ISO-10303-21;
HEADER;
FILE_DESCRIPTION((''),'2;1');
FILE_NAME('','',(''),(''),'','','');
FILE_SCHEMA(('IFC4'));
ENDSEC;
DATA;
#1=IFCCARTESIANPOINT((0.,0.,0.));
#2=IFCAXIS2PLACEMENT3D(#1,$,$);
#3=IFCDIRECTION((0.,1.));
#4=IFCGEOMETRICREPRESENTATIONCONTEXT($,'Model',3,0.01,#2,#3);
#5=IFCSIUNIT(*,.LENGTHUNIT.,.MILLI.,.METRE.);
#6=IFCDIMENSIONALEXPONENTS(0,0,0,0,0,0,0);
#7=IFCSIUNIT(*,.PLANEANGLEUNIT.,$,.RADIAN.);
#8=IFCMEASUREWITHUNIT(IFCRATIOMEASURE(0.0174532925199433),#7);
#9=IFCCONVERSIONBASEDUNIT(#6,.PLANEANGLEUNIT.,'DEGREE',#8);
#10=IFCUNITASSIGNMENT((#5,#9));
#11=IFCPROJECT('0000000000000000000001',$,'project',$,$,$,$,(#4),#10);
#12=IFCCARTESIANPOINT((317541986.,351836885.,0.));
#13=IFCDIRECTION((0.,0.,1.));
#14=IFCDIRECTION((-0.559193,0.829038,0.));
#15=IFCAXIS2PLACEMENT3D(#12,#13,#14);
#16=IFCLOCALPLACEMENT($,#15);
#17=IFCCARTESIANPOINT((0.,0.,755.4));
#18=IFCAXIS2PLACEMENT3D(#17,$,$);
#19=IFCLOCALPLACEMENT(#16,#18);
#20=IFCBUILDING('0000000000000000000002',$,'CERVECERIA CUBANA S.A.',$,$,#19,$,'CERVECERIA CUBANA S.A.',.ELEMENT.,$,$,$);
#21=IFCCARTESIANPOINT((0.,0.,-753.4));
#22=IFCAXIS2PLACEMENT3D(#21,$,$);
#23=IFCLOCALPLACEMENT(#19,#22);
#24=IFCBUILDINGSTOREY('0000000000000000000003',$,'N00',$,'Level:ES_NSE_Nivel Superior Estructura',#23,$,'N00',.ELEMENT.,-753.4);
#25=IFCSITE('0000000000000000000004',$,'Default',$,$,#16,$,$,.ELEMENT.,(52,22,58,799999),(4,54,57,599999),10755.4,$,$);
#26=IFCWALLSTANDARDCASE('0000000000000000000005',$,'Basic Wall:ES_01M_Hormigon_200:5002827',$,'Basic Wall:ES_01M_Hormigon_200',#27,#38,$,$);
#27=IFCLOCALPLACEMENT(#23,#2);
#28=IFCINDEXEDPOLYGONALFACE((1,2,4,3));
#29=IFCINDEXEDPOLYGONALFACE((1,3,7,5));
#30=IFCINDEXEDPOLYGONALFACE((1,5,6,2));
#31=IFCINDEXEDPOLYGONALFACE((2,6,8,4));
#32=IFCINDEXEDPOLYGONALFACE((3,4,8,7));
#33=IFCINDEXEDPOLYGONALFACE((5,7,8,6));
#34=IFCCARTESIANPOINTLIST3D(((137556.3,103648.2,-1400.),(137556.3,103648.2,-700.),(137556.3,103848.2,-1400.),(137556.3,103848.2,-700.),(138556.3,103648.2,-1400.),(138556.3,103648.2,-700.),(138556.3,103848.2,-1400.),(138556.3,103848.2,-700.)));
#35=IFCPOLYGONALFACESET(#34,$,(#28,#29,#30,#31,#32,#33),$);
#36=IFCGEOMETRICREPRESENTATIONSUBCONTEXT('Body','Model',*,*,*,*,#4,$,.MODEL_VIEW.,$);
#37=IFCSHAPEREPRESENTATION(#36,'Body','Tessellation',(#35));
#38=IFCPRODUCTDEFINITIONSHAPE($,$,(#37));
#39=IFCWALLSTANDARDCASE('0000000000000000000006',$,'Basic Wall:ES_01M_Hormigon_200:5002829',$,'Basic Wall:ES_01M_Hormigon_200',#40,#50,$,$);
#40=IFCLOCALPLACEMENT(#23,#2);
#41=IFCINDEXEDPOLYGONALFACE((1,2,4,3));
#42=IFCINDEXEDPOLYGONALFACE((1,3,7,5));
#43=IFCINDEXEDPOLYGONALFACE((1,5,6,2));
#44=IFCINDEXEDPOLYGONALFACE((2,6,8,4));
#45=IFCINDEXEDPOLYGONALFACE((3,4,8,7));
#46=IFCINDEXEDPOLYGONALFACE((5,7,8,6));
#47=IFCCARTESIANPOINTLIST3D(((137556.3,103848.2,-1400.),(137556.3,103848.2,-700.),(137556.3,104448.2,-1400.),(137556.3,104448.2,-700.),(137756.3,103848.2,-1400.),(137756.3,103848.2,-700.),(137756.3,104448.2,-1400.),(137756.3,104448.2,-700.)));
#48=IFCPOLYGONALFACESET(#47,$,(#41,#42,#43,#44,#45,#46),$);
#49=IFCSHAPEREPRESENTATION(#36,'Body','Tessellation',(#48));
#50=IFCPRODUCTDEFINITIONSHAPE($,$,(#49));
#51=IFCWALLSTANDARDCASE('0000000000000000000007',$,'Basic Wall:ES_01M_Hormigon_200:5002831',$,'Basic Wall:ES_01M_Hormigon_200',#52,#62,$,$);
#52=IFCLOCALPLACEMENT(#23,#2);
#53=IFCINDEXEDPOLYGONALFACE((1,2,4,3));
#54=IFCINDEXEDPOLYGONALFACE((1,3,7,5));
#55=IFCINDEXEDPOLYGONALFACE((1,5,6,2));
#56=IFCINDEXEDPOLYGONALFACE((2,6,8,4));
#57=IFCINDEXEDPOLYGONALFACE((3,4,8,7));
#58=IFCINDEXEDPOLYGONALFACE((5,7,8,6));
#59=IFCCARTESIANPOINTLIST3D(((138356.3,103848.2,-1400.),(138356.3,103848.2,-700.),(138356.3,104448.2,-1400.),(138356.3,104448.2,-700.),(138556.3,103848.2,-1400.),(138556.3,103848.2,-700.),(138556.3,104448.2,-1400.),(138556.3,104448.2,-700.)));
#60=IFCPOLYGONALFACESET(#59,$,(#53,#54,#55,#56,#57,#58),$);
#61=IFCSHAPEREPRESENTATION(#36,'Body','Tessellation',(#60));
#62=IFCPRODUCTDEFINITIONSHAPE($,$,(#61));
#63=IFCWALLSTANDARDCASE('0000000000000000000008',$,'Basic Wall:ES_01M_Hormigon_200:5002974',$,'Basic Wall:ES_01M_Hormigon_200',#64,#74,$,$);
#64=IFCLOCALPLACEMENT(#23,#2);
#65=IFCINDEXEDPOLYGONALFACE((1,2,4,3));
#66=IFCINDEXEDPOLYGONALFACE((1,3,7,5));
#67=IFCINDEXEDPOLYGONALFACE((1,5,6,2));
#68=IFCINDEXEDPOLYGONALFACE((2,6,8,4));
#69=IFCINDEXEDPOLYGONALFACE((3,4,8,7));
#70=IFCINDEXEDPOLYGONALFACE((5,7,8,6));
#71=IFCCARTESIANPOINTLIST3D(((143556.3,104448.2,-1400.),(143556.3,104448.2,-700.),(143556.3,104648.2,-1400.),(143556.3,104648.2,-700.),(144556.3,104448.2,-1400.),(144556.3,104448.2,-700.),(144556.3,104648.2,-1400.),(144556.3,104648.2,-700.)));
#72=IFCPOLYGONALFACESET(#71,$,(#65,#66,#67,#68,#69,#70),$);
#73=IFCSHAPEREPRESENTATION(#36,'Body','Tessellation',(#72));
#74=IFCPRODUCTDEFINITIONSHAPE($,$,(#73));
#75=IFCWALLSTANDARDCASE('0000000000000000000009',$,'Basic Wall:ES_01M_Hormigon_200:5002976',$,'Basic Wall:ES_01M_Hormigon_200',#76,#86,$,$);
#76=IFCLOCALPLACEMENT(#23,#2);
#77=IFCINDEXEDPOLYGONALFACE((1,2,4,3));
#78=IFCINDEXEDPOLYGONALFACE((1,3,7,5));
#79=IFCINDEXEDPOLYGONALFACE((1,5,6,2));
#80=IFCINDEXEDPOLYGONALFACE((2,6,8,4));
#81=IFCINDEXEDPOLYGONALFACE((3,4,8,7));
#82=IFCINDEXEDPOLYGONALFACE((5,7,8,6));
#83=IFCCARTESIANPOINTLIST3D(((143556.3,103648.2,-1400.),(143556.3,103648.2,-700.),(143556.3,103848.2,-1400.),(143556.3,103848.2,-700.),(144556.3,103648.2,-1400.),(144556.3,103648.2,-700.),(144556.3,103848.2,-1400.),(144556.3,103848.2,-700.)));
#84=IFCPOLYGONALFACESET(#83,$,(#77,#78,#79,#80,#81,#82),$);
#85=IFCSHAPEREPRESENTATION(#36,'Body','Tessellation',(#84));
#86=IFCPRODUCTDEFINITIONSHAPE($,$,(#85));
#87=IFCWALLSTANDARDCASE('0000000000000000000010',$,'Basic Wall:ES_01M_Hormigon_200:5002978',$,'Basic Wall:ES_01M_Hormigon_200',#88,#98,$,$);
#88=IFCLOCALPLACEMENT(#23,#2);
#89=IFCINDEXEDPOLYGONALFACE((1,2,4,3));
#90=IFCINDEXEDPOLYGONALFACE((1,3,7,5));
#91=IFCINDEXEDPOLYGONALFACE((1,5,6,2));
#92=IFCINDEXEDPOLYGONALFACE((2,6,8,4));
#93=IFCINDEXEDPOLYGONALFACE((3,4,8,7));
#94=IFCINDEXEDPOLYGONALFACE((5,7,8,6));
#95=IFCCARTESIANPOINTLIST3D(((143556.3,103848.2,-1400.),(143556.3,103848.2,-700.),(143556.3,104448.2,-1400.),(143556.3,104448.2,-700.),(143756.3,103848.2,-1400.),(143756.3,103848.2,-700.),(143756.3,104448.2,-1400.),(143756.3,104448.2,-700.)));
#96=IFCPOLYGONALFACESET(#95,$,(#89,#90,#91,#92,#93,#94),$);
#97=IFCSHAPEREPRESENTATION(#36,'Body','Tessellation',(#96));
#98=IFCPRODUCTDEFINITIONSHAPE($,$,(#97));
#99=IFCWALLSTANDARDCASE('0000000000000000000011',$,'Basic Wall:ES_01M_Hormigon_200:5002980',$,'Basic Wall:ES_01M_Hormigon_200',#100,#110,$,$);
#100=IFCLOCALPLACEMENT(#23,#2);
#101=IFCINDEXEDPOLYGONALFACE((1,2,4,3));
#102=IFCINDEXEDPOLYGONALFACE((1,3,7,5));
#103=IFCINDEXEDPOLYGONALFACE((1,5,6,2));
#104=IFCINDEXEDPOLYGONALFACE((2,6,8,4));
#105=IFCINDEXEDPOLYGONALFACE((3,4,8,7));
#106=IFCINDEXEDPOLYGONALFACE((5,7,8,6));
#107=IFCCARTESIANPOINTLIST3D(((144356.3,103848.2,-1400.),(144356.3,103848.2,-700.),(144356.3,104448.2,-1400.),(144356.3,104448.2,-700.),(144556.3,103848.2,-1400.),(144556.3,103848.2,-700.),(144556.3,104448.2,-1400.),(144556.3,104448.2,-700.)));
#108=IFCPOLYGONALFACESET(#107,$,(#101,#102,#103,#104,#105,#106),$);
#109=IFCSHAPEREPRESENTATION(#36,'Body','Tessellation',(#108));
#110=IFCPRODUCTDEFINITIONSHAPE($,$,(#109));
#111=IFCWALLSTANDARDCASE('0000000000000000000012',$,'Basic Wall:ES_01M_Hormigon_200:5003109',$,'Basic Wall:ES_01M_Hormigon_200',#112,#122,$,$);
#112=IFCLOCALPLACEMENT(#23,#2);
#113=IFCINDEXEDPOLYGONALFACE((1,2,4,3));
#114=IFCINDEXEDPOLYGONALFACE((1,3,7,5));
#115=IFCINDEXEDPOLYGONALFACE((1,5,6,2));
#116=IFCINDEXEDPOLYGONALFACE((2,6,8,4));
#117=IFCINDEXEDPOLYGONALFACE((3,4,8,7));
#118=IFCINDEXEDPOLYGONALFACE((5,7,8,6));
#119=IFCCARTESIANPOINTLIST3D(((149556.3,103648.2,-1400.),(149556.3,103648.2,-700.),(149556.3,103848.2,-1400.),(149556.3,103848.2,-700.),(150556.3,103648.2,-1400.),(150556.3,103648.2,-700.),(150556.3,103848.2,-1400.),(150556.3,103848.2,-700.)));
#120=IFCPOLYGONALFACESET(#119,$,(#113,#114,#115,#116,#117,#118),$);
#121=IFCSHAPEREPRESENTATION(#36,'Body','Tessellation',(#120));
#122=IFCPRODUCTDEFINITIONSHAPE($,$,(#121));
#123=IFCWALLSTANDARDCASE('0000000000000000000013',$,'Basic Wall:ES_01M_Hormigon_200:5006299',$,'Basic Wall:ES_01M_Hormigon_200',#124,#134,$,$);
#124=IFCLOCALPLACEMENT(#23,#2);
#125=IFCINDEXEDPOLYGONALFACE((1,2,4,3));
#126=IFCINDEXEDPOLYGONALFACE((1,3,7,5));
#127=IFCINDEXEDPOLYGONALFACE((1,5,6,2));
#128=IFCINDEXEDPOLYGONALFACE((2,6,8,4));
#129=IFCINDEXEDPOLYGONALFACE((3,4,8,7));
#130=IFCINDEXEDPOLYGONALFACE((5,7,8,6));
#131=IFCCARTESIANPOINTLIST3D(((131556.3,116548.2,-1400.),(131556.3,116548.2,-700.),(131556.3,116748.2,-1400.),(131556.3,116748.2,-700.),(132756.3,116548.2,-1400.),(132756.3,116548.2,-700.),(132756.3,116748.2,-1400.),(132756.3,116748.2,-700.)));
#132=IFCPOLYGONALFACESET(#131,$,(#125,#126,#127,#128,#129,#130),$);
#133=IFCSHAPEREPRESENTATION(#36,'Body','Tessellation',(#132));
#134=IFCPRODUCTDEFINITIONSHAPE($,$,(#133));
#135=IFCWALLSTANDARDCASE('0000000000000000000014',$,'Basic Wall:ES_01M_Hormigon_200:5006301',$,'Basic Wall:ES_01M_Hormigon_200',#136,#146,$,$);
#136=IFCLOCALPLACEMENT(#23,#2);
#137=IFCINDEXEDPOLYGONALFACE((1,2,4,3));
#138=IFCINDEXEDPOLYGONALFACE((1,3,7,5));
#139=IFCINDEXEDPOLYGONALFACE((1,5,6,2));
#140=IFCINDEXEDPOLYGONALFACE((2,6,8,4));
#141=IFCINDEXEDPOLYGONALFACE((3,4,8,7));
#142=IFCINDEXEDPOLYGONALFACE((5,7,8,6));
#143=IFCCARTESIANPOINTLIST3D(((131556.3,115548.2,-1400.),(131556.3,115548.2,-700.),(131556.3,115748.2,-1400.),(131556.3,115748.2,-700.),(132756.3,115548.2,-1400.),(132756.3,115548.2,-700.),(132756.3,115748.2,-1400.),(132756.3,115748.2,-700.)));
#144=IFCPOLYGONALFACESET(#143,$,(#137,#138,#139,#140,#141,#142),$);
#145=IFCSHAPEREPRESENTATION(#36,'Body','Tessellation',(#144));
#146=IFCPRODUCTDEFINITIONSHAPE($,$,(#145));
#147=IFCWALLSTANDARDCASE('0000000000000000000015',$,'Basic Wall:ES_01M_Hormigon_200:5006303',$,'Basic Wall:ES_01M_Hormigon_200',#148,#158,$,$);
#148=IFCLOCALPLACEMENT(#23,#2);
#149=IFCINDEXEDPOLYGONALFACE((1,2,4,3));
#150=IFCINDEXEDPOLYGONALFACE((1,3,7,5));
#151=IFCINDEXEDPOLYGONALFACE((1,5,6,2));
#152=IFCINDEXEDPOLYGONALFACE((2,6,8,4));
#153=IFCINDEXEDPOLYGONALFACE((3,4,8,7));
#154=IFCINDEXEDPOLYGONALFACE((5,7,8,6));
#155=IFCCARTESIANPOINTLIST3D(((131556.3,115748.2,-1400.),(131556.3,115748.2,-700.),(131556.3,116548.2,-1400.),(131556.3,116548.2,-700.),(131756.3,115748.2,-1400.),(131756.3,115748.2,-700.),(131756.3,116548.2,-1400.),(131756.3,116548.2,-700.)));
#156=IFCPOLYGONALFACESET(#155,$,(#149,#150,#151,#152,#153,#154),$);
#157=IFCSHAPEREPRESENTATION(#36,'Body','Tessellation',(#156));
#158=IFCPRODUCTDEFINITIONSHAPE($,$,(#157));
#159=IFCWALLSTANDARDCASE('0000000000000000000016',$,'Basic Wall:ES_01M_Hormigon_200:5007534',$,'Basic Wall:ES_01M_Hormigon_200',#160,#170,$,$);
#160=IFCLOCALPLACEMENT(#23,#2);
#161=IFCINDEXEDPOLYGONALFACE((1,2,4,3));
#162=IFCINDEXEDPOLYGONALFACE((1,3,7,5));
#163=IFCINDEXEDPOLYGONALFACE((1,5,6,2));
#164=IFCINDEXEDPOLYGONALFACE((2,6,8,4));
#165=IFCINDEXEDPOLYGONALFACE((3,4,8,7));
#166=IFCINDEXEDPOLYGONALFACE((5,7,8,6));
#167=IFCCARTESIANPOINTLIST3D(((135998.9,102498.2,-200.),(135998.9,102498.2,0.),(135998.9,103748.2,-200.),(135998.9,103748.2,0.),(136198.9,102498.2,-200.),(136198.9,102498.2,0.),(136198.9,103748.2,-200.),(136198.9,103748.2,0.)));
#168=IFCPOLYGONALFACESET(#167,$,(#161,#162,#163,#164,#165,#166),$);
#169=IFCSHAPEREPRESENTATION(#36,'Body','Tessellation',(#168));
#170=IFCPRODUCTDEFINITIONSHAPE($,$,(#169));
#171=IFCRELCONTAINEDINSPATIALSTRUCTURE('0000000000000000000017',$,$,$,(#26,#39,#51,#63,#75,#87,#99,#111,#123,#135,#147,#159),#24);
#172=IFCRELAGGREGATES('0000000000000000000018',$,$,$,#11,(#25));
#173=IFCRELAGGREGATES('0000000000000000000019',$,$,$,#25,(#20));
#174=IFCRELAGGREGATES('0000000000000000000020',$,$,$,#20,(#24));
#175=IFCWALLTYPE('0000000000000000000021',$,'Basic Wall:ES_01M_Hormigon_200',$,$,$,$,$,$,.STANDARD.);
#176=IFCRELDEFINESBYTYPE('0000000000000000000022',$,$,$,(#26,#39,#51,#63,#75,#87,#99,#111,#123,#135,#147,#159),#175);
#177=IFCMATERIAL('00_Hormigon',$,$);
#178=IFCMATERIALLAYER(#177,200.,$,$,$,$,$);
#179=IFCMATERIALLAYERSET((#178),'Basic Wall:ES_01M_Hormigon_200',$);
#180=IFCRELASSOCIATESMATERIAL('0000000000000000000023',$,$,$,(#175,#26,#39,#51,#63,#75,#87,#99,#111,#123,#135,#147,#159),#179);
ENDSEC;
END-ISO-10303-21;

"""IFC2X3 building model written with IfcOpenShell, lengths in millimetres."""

from ifc_helpers import new_model, entity, si_unit, converted_unit, direction, frame, frame_2d, origin, place, context, subcontext, project, spatial, rectangle, extrude, material, layer, layer_set, layer_usage, type_object, element, save


model = new_model("IFC2X3")

# Units and contexts
model_context = context("Model", 3, precision=0.01, world=origin(), true_north=direction((0.0, 1.0)))
body_context = subcontext(model_context, "Body", "Model", "MODEL_VIEW")
ifc_project = project(units=[si_unit("LENGTHUNIT", "METRE", prefix="MILLI"), converted_unit("PLANEANGLEUNIT", "DEGREE", entity("IfcRatioMeasure", 0.0174532925199433), si_unit("PLANEANGLEUNIT", "RADIAN"), dimensions=[0, 0, 0, 0, 0, 0, 0])], contexts=[model_context])

# Site, building, storey
site_placement = place(None, frame((317541986.0, 351836885.0, 0.0), z_axis=(0.0, 0.0, 1.0), x_axis=(-0.559193, 0.829038, 0.0)))
site = spatial("IfcSite", under=ifc_project, at=site_placement, Name="Default", CompositionType="ELEMENT", RefLatitude=(52, 22, 58, 799999), RefLongitude=(4, 54, 57, 599999), RefElevation=10755.4)
building_placement = place(site_placement, frame((0.0, 0.0, 755.4)))
building = spatial("IfcBuilding", under=site, at=building_placement, Name="CERVECERIA CUBANA S.A.", LongName="CERVECERIA CUBANA S.A.", CompositionType="ELEMENT")
storey_placement = place(building_placement, frame((0.0, 0.0, -753.4)))
storey = spatial("IfcBuildingStorey", under=building, at=storey_placement, Name="N00", ObjectType="Level:ES_NSE_Nivel Superior Estructura", LongName="N00", CompositionType="ELEMENT", Elevation=-753.4)

# Shared definitions
ifc_material = material(Name="00_Hormigon")

# Walls
ifc_layer_1 = layer(ifc_material, 200.0)
ifc_layer_set_1 = layer_set([ifc_layer_1], Name="Basic Wall:ES_01M_Hormigon_200")
wall_type = type_object("IfcWallType", Name="Basic Wall:ES_01M_Hormigon_200", PredefinedType="STANDARD", material=ifc_layer_set_1)
ifc_layer_usage_1 = layer_usage(ifc_layer_set_1, "AXIS2", "POSITIVE", -100.0)
wall_1_placement = place(storey_placement, frame((137556.3, 103748.2, -1400.0)))
element("IfcWallStandardCase", 1, at=wall_1_placement, inside=storey, type_object=wall_type, material=ifc_layer_usage_1, Name="Basic Wall:ES_01M_Hormigon_200:5002827", ObjectType="Basic Wall:ES_01M_Hormigon_200", context=body_context, shape_type="SweptSolid", body=[
    extrude(rectangle(XDim=1000.0, YDim=200.0, at=frame_2d((500.0, 0.0), x_axis=(-1.0, 0.0))), origin(), (0.0, 0.0, 1.0), 700.0),
])
ifc_layer_usage_2 = layer_usage(ifc_layer_set_1, "AXIS2", "POSITIVE", -100.0)
wall_2_placement = place(storey_placement, frame((137656.3, 104448.2, -1400.0), z_axis=(0.0, 0.0, 1.0), x_axis=(0.0, -1.0, 0.0)))
element("IfcWallStandardCase", 2, at=wall_2_placement, inside=storey, type_object=wall_type, material=ifc_layer_usage_2, Name="Basic Wall:ES_01M_Hormigon_200:5002829", ObjectType="Basic Wall:ES_01M_Hormigon_200", context=body_context, shape_type="SweptSolid", body=[
    extrude(rectangle(XDim=600.0, YDim=200.0, at=frame_2d((300.0, 0.0), x_axis=(-1.0, 0.0))), origin(), (0.0, 0.0, 1.0), 700.0),
])
ifc_layer_usage_3 = layer_usage(ifc_layer_set_1, "AXIS2", "NEGATIVE", 100.0)
wall_3_placement = place(storey_placement, frame((138456.3, 104448.2, -1400.0), z_axis=(0.0, 0.0, 1.0), x_axis=(0.0, -1.0, 0.0)))
element("IfcWallStandardCase", 3, at=wall_3_placement, inside=storey, type_object=wall_type, material=ifc_layer_usage_3, Name="Basic Wall:ES_01M_Hormigon_200:5002831", ObjectType="Basic Wall:ES_01M_Hormigon_200", context=body_context, shape_type="SweptSolid", body=[
    extrude(rectangle(XDim=600.0, YDim=200.0, at=frame_2d((300.0, 0.0), x_axis=(-1.0, 0.0))), origin(), (0.0, 0.0, 1.0), 700.0),
])
ifc_layer_usage_4 = layer_usage(ifc_layer_set_1, "AXIS2", "NEGATIVE", 100.0)
wall_4_placement = place(storey_placement, frame((143556.3, 104548.2, -1400.0)))
element("IfcWallStandardCase", 4, at=wall_4_placement, inside=storey, type_object=wall_type, material=ifc_layer_usage_4, Name="Basic Wall:ES_01M_Hormigon_200:5002974", ObjectType="Basic Wall:ES_01M_Hormigon_200", context=body_context, shape_type="SweptSolid", body=[
    extrude(rectangle(XDim=1000.0, YDim=200.0, at=frame_2d((500.0, 0.0), x_axis=(-1.0, 0.0))), origin(), (0.0, 0.0, 1.0), 700.0),
])
ifc_layer_usage_5 = layer_usage(ifc_layer_set_1, "AXIS2", "POSITIVE", -100.0)
wall_5_placement = place(storey_placement, frame((143556.3, 103748.2, -1400.0)))
element("IfcWallStandardCase", 5, at=wall_5_placement, inside=storey, type_object=wall_type, material=ifc_layer_usage_5, Name="Basic Wall:ES_01M_Hormigon_200:5002976", ObjectType="Basic Wall:ES_01M_Hormigon_200", context=body_context, shape_type="SweptSolid", body=[
    extrude(rectangle(XDim=1000.0, YDim=200.0, at=frame_2d((500.0, 0.0), x_axis=(-1.0, 0.0))), origin(), (0.0, 0.0, 1.0), 700.0),
])
ifc_layer_usage_6 = layer_usage(ifc_layer_set_1, "AXIS2", "POSITIVE", -100.0)
wall_6_placement = place(storey_placement, frame((143656.3, 104448.2, -1400.0), z_axis=(0.0, 0.0, 1.0), x_axis=(0.0, -1.0, 0.0)))
element("IfcWallStandardCase", 6, at=wall_6_placement, inside=storey, type_object=wall_type, material=ifc_layer_usage_6, Name="Basic Wall:ES_01M_Hormigon_200:5002978", ObjectType="Basic Wall:ES_01M_Hormigon_200", context=body_context, shape_type="SweptSolid", body=[
    extrude(rectangle(XDim=600.0, YDim=200.0, at=frame_2d((300.0, 0.0), x_axis=(-1.0, 0.0))), origin(), (0.0, 0.0, 1.0), 700.0),
])
ifc_layer_usage_7 = layer_usage(ifc_layer_set_1, "AXIS2", "NEGATIVE", 100.0)
wall_7_placement = place(storey_placement, frame((144456.3, 104448.2, -1400.0), z_axis=(0.0, 0.0, 1.0), x_axis=(0.0, -1.0, 0.0)))
element("IfcWallStandardCase", 7, at=wall_7_placement, inside=storey, type_object=wall_type, material=ifc_layer_usage_7, Name="Basic Wall:ES_01M_Hormigon_200:5002980", ObjectType="Basic Wall:ES_01M_Hormigon_200", context=body_context, shape_type="SweptSolid", body=[
    extrude(rectangle(XDim=600.0, YDim=200.0, at=frame_2d((300.0, 0.0), x_axis=(-1.0, 0.0))), origin(), (0.0, 0.0, 1.0), 700.0),
])
ifc_layer_usage_8 = layer_usage(ifc_layer_set_1, "AXIS2", "POSITIVE", -100.0)
wall_8_placement = place(storey_placement, frame((149556.3, 103748.2, -1400.0)))
element("IfcWallStandardCase", 8, at=wall_8_placement, inside=storey, type_object=wall_type, material=ifc_layer_usage_8, Name="Basic Wall:ES_01M_Hormigon_200:5003109", ObjectType="Basic Wall:ES_01M_Hormigon_200", context=body_context, shape_type="SweptSolid", body=[
    extrude(rectangle(XDim=1000.0, YDim=200.0, at=frame_2d((500.0, 0.0), x_axis=(-1.0, 0.0))), origin(), (0.0, 0.0, 1.0), 700.0),
])
ifc_layer_usage_9 = layer_usage(ifc_layer_set_1, "AXIS2", "NEGATIVE", 100.0)
wall_9_placement = place(storey_placement, frame((131556.3, 116648.2, -1400.0)))
element("IfcWallStandardCase", 9, at=wall_9_placement, inside=storey, type_object=wall_type, material=ifc_layer_usage_9, Name="Basic Wall:ES_01M_Hormigon_200:5006299", ObjectType="Basic Wall:ES_01M_Hormigon_200", context=body_context, shape_type="SweptSolid", body=[
    extrude(rectangle(XDim=1200.0, YDim=200.0, at=frame_2d((600.0, 0.0), x_axis=(-1.0, 0.0))), origin(), (0.0, 0.0, 1.0), 700.0),
])
ifc_layer_usage_10 = layer_usage(ifc_layer_set_1, "AXIS2", "POSITIVE", -100.0)
wall_10_placement = place(storey_placement, frame((131556.3, 115648.2, -1400.0)))
element("IfcWallStandardCase", 10, at=wall_10_placement, inside=storey, type_object=wall_type, material=ifc_layer_usage_10, Name="Basic Wall:ES_01M_Hormigon_200:5006301", ObjectType="Basic Wall:ES_01M_Hormigon_200", context=body_context, shape_type="SweptSolid", body=[
    extrude(rectangle(XDim=1200.0, YDim=200.0, at=frame_2d((600.0, 0.0), x_axis=(-1.0, 0.0))), origin(), (0.0, 0.0, 1.0), 700.0),
])
ifc_layer_usage_11 = layer_usage(ifc_layer_set_1, "AXIS2", "POSITIVE", -100.0)
wall_11_placement = place(storey_placement, frame((131656.3, 116548.2, -1400.0), z_axis=(0.0, 0.0, 1.0), x_axis=(0.0, -1.0, 0.0)))
element("IfcWallStandardCase", 11, at=wall_11_placement, inside=storey, type_object=wall_type, material=ifc_layer_usage_11, Name="Basic Wall:ES_01M_Hormigon_200:5006303", ObjectType="Basic Wall:ES_01M_Hormigon_200", context=body_context, shape_type="SweptSolid", body=[
    extrude(rectangle(XDim=800.0, YDim=200.0, at=frame_2d((400.0, 0.0), x_axis=(-1.0, 0.0))), origin(), (0.0, 0.0, 1.0), 700.0),
])
ifc_layer_usage_12 = layer_usage(ifc_layer_set_1, "AXIS2", "POSITIVE", -100.0)
wall_12_placement = place(storey_placement, frame((136098.9, 103748.2, -200.0), z_axis=(0.0, 0.0, 1.0), x_axis=(0.0, -1.0, 0.0)))
element("IfcWallStandardCase", 12, at=wall_12_placement, inside=storey, type_object=wall_type, material=ifc_layer_usage_12, Name="Basic Wall:ES_01M_Hormigon_200:5007534", ObjectType="Basic Wall:ES_01M_Hormigon_200", context=body_context, shape_type="SweptSolid", body=[
    extrude(rectangle(XDim=1250.0, YDim=200.0, at=frame_2d((625.0, 0.0), x_axis=(-1.0, 0.0))), origin(), (0.0, 0.0, 1.0), 200.0),
])

save(model, "model.ifc")
